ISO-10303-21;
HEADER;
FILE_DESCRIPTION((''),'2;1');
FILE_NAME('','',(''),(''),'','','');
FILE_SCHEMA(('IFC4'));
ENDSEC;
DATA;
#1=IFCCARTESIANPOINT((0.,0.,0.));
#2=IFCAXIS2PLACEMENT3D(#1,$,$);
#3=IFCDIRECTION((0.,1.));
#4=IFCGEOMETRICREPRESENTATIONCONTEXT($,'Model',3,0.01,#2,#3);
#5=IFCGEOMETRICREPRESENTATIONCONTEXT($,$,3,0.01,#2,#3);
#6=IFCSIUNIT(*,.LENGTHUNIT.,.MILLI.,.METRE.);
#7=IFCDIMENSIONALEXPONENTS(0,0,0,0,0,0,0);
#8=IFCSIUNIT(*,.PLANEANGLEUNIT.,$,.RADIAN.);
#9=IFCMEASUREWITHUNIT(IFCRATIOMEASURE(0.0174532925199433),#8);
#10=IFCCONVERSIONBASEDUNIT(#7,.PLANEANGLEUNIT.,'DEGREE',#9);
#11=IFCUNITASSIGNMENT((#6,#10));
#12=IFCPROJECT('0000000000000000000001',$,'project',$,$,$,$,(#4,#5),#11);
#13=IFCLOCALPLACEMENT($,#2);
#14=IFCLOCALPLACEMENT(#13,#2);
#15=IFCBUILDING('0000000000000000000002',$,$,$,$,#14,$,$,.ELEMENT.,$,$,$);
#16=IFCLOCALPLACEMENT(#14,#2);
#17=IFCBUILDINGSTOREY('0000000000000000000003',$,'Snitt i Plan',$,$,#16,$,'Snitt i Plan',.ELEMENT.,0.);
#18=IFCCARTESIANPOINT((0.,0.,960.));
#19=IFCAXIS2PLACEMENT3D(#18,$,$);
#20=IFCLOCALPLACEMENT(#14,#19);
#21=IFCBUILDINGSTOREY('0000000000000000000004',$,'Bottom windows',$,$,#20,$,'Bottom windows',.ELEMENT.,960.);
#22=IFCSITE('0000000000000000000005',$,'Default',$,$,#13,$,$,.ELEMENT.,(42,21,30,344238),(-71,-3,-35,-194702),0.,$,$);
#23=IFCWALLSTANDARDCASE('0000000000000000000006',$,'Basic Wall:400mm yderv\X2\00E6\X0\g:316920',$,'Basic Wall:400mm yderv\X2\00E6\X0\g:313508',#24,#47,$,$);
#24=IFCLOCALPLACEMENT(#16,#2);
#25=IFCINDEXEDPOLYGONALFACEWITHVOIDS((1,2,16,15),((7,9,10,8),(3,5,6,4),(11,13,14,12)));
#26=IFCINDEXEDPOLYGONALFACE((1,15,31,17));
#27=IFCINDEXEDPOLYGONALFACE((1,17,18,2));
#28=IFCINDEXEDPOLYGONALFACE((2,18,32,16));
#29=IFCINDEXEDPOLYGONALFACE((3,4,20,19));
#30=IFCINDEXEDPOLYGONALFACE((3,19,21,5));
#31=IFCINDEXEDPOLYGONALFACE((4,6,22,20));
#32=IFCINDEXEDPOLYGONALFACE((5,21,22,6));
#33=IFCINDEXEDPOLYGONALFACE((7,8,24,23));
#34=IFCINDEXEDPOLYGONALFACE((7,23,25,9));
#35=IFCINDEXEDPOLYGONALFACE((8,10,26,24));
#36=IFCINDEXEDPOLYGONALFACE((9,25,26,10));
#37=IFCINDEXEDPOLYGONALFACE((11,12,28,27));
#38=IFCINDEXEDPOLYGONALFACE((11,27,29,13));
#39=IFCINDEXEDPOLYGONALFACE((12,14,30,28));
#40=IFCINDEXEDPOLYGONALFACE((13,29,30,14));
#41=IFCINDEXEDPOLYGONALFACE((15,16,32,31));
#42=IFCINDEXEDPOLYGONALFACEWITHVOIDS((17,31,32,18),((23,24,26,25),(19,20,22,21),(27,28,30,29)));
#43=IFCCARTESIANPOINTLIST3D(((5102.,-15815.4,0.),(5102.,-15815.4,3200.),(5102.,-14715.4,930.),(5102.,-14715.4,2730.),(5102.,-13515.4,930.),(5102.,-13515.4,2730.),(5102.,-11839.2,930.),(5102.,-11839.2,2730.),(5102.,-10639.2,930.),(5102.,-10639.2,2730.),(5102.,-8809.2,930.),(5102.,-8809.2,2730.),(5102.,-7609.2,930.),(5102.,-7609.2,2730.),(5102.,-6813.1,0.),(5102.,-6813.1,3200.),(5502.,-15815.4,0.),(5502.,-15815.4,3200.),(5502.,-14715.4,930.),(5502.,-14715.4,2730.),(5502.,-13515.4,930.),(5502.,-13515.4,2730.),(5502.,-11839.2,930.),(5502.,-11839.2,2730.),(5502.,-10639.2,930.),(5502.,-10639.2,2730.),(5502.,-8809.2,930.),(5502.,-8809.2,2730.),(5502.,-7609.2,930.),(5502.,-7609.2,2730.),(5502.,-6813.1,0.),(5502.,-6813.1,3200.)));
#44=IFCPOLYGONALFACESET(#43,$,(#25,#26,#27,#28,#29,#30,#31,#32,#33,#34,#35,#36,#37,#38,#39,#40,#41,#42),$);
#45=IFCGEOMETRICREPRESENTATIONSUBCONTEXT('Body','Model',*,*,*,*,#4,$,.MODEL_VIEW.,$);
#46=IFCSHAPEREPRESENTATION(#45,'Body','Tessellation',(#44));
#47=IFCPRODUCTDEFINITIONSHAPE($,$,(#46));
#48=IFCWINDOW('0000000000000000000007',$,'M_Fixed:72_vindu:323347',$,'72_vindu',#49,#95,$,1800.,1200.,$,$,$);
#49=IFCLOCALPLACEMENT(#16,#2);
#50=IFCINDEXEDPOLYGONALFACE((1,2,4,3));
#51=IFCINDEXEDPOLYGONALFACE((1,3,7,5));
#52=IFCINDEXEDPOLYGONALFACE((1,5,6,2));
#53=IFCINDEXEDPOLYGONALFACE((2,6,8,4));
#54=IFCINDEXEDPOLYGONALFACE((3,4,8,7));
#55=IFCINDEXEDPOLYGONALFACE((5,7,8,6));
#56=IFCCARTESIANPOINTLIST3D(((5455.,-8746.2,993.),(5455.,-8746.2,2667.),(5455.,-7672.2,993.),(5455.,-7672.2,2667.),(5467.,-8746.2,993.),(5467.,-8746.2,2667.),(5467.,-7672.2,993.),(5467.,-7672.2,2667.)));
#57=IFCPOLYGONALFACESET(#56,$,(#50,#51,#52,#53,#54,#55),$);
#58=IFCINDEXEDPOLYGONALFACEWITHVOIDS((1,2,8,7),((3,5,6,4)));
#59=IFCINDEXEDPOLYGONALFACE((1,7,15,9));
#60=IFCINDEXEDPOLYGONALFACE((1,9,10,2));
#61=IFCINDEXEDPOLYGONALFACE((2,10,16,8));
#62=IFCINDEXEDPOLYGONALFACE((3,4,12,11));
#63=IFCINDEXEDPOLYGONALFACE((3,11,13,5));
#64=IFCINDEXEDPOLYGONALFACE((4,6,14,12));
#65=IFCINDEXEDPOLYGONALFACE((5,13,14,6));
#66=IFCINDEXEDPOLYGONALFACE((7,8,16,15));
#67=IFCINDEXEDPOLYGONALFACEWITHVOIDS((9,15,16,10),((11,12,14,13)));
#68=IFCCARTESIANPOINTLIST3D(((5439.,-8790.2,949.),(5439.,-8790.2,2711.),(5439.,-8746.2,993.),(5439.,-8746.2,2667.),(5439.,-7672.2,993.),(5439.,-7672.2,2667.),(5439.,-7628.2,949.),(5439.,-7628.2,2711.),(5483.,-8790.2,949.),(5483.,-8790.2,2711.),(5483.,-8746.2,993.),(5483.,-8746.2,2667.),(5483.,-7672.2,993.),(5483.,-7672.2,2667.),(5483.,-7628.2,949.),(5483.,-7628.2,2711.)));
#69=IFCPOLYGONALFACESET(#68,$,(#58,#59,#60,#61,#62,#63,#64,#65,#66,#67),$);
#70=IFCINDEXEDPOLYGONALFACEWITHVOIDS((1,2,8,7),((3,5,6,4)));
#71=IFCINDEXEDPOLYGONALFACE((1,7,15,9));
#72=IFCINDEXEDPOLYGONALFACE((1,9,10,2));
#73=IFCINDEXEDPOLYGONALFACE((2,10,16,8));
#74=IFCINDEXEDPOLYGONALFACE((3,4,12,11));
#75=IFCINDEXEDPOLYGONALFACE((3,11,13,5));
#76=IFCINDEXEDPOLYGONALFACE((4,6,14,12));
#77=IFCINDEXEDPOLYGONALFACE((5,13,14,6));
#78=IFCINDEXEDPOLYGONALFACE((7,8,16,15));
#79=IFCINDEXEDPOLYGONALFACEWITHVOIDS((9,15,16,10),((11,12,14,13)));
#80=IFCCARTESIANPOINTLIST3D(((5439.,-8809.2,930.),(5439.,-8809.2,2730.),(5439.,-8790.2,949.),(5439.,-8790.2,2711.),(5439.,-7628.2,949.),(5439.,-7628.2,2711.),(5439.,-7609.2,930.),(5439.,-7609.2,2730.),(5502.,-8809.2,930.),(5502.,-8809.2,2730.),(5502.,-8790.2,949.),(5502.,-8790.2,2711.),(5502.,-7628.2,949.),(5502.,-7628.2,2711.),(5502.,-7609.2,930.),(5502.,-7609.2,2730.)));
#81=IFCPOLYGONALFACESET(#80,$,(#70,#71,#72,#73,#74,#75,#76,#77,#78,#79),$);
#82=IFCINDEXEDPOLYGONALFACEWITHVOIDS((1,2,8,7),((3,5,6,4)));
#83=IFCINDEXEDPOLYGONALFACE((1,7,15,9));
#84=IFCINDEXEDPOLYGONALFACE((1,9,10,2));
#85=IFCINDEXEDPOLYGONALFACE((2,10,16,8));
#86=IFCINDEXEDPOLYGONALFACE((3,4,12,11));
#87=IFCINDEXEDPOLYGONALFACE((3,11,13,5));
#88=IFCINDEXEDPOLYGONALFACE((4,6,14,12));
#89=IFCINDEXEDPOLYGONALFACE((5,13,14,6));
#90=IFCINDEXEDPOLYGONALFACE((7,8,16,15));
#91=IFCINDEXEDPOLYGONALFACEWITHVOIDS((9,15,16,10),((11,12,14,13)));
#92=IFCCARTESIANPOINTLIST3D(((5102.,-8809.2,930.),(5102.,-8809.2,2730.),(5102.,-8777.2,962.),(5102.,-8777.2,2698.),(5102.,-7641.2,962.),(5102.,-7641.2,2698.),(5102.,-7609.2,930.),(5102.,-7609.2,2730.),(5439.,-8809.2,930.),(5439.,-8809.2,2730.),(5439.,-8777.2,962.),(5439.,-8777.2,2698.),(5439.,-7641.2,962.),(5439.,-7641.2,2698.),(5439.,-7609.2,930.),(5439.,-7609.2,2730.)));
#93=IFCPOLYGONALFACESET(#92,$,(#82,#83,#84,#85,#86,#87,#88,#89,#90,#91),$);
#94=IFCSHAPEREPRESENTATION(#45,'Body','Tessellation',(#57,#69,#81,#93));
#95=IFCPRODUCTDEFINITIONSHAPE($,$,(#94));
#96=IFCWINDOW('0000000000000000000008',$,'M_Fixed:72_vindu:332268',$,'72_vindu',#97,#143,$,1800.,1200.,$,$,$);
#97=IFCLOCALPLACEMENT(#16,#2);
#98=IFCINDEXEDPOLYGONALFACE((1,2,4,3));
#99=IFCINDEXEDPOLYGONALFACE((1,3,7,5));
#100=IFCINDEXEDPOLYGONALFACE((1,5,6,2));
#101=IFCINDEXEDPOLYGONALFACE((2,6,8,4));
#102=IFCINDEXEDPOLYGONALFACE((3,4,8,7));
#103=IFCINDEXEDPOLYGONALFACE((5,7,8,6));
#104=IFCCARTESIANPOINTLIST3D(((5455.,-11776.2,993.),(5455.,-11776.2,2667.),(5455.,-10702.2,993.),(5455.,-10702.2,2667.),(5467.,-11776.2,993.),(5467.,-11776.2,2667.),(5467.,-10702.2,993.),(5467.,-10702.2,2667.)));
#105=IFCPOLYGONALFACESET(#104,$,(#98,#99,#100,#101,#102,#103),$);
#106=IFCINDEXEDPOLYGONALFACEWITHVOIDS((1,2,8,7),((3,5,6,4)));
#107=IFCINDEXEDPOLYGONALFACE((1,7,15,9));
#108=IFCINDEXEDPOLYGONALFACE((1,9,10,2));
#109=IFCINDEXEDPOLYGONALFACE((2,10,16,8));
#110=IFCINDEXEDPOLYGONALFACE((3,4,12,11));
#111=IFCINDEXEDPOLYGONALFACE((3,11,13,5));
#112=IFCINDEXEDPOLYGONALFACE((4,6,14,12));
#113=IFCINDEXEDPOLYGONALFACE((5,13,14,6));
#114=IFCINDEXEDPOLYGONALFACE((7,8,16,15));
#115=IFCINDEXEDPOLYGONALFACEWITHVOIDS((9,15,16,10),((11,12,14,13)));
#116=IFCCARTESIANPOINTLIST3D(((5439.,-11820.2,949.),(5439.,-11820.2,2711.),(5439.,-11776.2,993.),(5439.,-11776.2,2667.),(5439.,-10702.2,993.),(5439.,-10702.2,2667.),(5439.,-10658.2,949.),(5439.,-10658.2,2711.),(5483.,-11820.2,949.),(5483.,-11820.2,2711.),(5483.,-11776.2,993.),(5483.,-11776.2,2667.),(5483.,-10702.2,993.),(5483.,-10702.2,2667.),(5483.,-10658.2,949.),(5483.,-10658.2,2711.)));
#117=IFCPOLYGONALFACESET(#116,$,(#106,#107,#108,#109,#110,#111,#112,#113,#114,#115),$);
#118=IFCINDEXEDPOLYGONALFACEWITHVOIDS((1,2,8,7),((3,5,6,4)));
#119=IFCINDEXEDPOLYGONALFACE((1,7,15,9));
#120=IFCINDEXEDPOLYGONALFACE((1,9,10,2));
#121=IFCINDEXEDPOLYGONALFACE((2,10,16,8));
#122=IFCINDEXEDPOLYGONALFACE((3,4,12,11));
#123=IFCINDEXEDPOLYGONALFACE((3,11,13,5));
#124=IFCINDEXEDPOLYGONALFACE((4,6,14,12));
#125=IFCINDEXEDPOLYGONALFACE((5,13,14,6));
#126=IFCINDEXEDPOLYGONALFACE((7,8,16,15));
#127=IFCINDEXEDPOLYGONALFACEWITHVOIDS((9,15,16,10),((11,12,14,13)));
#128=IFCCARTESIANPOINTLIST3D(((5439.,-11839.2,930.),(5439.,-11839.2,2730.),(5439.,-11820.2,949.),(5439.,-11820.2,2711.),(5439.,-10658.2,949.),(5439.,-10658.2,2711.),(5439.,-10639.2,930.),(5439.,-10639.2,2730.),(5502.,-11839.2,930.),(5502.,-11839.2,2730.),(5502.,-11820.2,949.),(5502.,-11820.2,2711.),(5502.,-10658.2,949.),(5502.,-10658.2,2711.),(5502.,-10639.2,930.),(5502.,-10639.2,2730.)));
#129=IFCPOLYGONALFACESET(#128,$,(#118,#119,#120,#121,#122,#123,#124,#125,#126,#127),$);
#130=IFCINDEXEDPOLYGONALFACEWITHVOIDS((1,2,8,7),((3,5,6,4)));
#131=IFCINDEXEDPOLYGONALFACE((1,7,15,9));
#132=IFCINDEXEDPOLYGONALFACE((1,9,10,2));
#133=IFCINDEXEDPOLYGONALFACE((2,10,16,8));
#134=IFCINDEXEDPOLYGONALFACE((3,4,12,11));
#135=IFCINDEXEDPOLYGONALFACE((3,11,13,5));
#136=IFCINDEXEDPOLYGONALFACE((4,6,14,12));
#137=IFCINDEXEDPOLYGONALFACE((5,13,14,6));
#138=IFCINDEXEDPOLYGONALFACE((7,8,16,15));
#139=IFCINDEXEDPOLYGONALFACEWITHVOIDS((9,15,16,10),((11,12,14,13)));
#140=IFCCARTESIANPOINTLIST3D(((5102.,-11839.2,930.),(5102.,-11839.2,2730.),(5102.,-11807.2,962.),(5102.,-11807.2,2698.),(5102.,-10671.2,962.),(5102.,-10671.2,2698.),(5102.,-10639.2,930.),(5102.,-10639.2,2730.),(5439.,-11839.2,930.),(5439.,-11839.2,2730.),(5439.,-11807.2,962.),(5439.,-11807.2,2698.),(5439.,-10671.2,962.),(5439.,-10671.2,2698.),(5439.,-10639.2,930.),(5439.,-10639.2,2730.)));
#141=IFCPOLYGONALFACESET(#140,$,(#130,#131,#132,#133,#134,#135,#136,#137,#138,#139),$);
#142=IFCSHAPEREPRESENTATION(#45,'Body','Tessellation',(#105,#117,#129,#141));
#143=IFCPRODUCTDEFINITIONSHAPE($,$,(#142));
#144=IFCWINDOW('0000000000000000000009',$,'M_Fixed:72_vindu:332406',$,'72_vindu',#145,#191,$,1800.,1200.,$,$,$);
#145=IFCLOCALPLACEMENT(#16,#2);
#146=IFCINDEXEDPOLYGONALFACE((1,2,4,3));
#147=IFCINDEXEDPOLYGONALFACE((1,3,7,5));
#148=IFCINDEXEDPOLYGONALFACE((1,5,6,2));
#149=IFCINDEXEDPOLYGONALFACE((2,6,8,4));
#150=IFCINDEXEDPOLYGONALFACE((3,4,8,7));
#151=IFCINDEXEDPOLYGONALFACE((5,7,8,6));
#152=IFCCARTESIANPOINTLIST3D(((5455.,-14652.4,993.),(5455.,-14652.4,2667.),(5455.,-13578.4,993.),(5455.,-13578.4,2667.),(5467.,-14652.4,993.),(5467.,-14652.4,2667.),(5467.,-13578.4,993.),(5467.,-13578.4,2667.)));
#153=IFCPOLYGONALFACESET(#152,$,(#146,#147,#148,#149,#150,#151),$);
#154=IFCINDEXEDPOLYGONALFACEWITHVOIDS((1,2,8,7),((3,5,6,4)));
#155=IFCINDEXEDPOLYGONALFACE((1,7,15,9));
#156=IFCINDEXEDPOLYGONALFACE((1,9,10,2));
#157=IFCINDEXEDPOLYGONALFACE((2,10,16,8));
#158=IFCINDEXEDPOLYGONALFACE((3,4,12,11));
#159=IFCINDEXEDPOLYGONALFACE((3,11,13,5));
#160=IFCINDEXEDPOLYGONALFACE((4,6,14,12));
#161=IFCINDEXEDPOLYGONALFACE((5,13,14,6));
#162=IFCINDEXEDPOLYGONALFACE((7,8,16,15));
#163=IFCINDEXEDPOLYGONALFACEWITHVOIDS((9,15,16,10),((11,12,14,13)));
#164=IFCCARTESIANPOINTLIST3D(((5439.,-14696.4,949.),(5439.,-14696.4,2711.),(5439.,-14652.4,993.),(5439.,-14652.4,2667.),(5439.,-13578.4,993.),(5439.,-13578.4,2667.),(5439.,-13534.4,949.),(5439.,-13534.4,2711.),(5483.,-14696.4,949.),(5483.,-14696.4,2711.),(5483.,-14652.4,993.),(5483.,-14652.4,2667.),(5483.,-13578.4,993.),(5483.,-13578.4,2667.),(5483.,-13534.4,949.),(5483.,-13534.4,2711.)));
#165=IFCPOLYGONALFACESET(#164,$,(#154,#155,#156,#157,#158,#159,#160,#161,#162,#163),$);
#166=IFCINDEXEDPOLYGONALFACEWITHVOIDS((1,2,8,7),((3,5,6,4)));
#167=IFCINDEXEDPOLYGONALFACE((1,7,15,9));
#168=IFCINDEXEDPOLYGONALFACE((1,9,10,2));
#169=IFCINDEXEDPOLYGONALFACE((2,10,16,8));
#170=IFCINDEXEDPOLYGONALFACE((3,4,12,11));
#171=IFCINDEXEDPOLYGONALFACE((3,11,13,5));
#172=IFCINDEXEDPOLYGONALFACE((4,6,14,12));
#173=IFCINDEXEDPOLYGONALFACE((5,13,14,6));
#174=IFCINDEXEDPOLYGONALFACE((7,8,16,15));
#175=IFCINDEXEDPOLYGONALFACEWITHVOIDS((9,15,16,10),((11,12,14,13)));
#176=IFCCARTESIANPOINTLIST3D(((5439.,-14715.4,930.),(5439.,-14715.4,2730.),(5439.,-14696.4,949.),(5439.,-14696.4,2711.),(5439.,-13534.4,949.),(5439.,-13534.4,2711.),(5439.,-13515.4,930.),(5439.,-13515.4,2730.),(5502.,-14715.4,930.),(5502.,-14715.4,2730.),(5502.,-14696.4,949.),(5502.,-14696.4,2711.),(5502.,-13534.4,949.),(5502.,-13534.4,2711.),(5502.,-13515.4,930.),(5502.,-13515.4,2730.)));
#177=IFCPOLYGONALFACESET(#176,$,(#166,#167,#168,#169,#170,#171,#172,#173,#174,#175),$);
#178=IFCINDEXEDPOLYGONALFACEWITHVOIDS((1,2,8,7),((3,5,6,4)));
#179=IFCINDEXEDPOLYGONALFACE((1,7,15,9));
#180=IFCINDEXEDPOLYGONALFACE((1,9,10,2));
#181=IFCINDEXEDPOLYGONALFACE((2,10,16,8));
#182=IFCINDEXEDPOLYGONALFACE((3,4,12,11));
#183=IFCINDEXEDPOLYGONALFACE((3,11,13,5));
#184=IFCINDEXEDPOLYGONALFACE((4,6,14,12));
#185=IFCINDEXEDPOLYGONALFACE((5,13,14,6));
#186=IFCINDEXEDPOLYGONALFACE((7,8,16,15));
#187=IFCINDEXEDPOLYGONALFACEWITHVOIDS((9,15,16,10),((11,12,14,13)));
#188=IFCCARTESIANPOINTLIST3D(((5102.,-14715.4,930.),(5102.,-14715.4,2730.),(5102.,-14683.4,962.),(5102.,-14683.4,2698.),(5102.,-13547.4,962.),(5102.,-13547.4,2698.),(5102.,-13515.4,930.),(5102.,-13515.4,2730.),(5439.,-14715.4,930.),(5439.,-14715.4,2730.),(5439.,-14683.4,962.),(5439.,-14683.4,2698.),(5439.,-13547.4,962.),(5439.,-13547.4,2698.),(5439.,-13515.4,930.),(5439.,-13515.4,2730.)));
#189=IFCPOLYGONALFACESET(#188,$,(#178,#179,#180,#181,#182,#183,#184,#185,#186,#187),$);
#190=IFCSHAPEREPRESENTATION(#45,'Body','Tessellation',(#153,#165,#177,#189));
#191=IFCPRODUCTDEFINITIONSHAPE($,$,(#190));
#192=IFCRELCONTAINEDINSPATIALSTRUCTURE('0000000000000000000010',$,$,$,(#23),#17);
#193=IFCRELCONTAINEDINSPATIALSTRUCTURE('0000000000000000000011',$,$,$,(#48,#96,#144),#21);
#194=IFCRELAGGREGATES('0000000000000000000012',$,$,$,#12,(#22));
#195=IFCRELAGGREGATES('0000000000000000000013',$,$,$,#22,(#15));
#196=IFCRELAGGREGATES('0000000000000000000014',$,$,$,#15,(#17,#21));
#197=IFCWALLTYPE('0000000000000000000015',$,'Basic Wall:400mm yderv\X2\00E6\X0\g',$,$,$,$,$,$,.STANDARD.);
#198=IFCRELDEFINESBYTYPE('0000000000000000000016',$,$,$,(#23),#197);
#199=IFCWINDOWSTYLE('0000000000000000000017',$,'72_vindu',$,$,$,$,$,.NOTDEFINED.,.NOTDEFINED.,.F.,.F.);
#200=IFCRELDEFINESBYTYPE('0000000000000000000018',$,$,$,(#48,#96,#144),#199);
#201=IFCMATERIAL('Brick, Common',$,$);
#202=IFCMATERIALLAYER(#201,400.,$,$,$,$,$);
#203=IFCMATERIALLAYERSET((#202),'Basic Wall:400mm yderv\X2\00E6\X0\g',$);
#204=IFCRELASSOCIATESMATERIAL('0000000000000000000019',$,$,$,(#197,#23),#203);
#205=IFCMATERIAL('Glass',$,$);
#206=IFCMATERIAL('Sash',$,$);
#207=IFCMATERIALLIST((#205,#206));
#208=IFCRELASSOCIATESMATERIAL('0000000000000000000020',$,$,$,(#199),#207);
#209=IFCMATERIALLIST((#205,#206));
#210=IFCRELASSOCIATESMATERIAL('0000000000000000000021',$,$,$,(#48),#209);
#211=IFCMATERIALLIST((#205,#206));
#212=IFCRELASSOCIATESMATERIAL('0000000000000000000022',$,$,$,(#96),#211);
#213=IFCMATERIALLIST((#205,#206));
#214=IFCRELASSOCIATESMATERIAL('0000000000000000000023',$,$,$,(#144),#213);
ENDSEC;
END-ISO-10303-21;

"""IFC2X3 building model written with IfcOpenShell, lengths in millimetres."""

from ifc_helpers import new_model, entity, si_unit, converted_unit, direction, frame, frame_2d, origin, origin_2d_with_axis, place, context, subcontext, project, spatial, polyline, rectangle, outline, extrude, source, transform, mapped, material, material_list, layer, layer_set, layer_usage, type_object, type_shapes, element, fill, save


model = new_model("IFC2X3")

# Units and contexts
model_context = context("Model", 3, precision=0.01, world=origin(), true_north=direction((0.0, 1.0)))
context_of_model = context(None, 3, precision=0.01, world=origin(), true_north=direction((0.0, 1.0)))
body_context = subcontext(model_context, "Body", "Model", "MODEL_VIEW")
ifc_project = project(units=[si_unit("LENGTHUNIT", "METRE", prefix="MILLI"), converted_unit("PLANEANGLEUNIT", "DEGREE", entity("IfcRatioMeasure", 0.0174532925199433), si_unit("PLANEANGLEUNIT", "RADIAN"), dimensions=[0, 0, 0, 0, 0, 0, 0])], contexts=[model_context, context_of_model])

# Site, building, storey
site_placement = place(None, origin())
site = spatial("IfcSite", under=ifc_project, at=site_placement, Name="Default", CompositionType="ELEMENT", RefLatitude=(42, 21, 30, 344238), RefLongitude=(-71, -3, -35, -194702), RefElevation=0.0)
building_placement = place(site_placement, origin())
building = spatial("IfcBuilding", under=site, at=building_placement, CompositionType="ELEMENT")
storey_1_placement = place(building_placement, origin())
storey_1 = spatial("IfcBuildingStorey", under=building, at=storey_1_placement, Name="Snitt i Plan", LongName="Snitt i Plan", CompositionType="ELEMENT", Elevation=0.0)

# Wall, openings
ifc_material_1 = material(Name="Brick, Common")
ifc_layer_1 = layer(ifc_material_1, 400.0)
ifc_layer_set_1 = layer_set([ifc_layer_1], Name="Basic Wall:400mm ydervæg")
ifc_layer_usage_1 = layer_usage(ifc_layer_set_1, "AXIS2", "NEGATIVE", 200.0)
wall_type_1 = type_object("IfcWallType", Name="Basic Wall:400mm ydervæg", PredefinedType="STANDARD", material=ifc_layer_set_1)
wall_1_placement = place(storey_1_placement, frame((5302.0, -6813.1, 0.0), z_axis=(0.0, 0.0, 1.0), x_axis=(0.0, -1.0, 0.0)))
wall_1 = element("IfcWallStandardCase", 1, at=wall_1_placement, inside=storey_1, type_object=wall_type_1, material=ifc_layer_usage_1, Name="Basic Wall:400mm ydervæg:316920", ObjectType="Basic Wall:400mm ydervæg:313508", context=body_context, shape_type="SweptSolid", body=[
    extrude(rectangle(XDim=9002.3, YDim=400.0, at=frame_2d((4501.2, 0.0), x_axis=(-1.0, 0.0))), origin(), (0.0, 0.0, 1.0), 3200.0),
])
opening_1_placement = place(wall_1_placement, frame((796.1, -200.0, 930.0)))
opening_1 = element("IfcOpeningElement", 2, at=opening_1_placement, cuts=wall_1, ObjectType="Opening", context=body_context, shape_type="SweptSolid", body=[
    extrude(rectangle(XDim=1800.0, YDim=1200.0, at=frame_2d((900.0, 600.0), x_axis=(1.0, 0.0))), frame((0.0, 0.0, 0.0), z_axis=(0.0, 1.0, 0.0), x_axis=(0.0, 0.0, 1.0)), (0.0, 0.0, 1.0), 400.0),
])
opening_2_placement = place(wall_1_placement, frame((3826.1, -200.0, 930.0)))
opening_2 = element("IfcOpeningElement", 3, at=opening_2_placement, cuts=wall_1, ObjectType="Opening", context=body_context, shape_type="SweptSolid", body=[
    extrude(rectangle(XDim=1800.0, YDim=1200.0, at=frame_2d((900.0, 600.0), x_axis=(1.0, 0.0))), frame((0.0, 0.0, 0.0), z_axis=(0.0, 1.0, 0.0), x_axis=(0.0, 0.0, 1.0)), (0.0, 0.0, 1.0), 400.0),
])
opening_3_placement = place(wall_1_placement, frame((6702.3, -200.0, 930.0)))
opening_3 = element("IfcOpeningElement", 4, at=opening_3_placement, cuts=wall_1, ObjectType="Opening", context=body_context, shape_type="SweptSolid", body=[
    extrude(rectangle(XDim=1800.0, YDim=1200.0, at=frame_2d((900.0, 600.0), x_axis=(1.0, 0.0))), frame((0.0, 0.0, 0.0), z_axis=(0.0, 1.0, 0.0), x_axis=(0.0, 0.0, 1.0)), (0.0, 0.0, 1.0), 400.0),
])

# Shared definitions
storey_2_placement = place(building_placement, frame((0.0, 0.0, 960.0)))
storey_2 = spatial("IfcBuildingStorey", under=building, at=storey_2_placement, Name="Bottom windows", LongName="Bottom windows", CompositionType="ELEMENT", Elevation=960.0)

# Windows
ifc_material_2 = material(Name="Glass")
ifc_material_3 = material(Name="Sash")
ifc_material_list_1 = material_list([ifc_material_2, ifc_material_3])
ifc_material_list_2 = material_list([ifc_material_2, ifc_material_3])
window_style_1 = type_object("IfcWindowStyle", Name="72_vindu", ConstructionType="NOTDEFINED", OperationType="NOTDEFINED", ParameterTakesPrecedence=False, Sizeable=False, material=ifc_material_list_2)
shared_shape_1 = source(origin(), body_context, "Body", "SweptSolid", [
    extrude(rectangle(XDim=12.0, YDim=1074.0, at=origin_2d_with_axis()), frame((600.0, 359.0, 63.0), z_axis=(0.0, 0.0, 1.0), x_axis=(0.0, -1.0, 0.0)), (0.0, 0.0, 1.0), 1674.0),
    extrude(outline(polyline([(-581.0, -881.0), (581.0, -881.0), (581.0, 881.0), (-581.0, 881.0), (-581.0, -881.0)]), holes=[polyline([(-537.0, -837.0), (-537.0, 837.0), (537.0, 837.0), (537.0, -837.0), (-537.0, -837.0)])]), frame((600.0, 337.0, 900.0), z_axis=(0.0, 1.0, 0.0), x_axis=(1.0, 0.0, 0.0)), (0.0, 0.0, 1.0), 44.0),
    extrude(outline(polyline([(-600.0, -900.0), (600.0, -900.0), (600.0, 900.0), (-600.0, 900.0), (-600.0, -900.0)]), holes=[polyline([(-581.0, -881.0), (-581.0, 881.0), (581.0, 881.0), (581.0, -881.0), (-581.0, -881.0)])]), frame((600.0, 337.0, 900.0), z_axis=(0.0, 1.0, 0.0), x_axis=(1.0, 0.0, 0.0)), (0.0, 0.0, 1.0), 63.0),
    extrude(outline(polyline([(-600.0, -900.0), (600.0, -900.0), (600.0, 900.0), (-600.0, 900.0), (-600.0, -900.0)]), holes=[polyline([(-568.0, -868.0), (-568.0, 868.0), (568.0, 868.0), (568.0, -868.0), (-568.0, -868.0)])]), frame((600.0, 0.0, 900.0), z_axis=(0.0, 1.0, 0.0), x_axis=(1.0, 0.0, 0.0)), (0.0, 0.0, 1.0), 337.0),
])
type_shapes(window_style_1, [shared_shape_1])
window_1_placement = place(opening_1_placement, origin())
window_1 = element("IfcWindow", 5, at=window_1_placement, inside=storey_2, type_object=window_style_1, material=ifc_material_list_1, Name="M_Fixed:72_vindu:323347", ObjectType="72_vindu", OverallHeight=1800.0, OverallWidth=1200.0, context=body_context, shape_type="MappedRepresentation", body=[
    mapped(shared_shape_1, transform((0.0, 0.0, 0.0), scale=1.0)),
])
fill(opening_1, window_1)
ifc_material_list_3 = material_list([ifc_material_2, ifc_material_3])
window_2_placement = place(opening_2_placement, origin())
window_2 = element("IfcWindow", 6, at=window_2_placement, inside=storey_2, type_object=window_style_1, material=ifc_material_list_3, Name="M_Fixed:72_vindu:332268", ObjectType="72_vindu", OverallHeight=1800.0, OverallWidth=1200.0, context=body_context, shape_type="MappedRepresentation", body=[
    mapped(shared_shape_1, transform((0.0, 0.0, 0.0), scale=1.0)),
])
fill(opening_2, window_2)
ifc_material_list_4 = material_list([ifc_material_2, ifc_material_3])
window_3_placement = place(opening_3_placement, origin())
window_3 = element("IfcWindow", 7, at=window_3_placement, inside=storey_2, type_object=window_style_1, material=ifc_material_list_4, Name="M_Fixed:72_vindu:332406", ObjectType="72_vindu", OverallHeight=1800.0, OverallWidth=1200.0, context=body_context, shape_type="MappedRepresentation", body=[
    mapped(shared_shape_1, transform((0.0, 0.0, 0.0), scale=1.0)),
])
fill(opening_3, window_3)

save(model, "model.ifc")
